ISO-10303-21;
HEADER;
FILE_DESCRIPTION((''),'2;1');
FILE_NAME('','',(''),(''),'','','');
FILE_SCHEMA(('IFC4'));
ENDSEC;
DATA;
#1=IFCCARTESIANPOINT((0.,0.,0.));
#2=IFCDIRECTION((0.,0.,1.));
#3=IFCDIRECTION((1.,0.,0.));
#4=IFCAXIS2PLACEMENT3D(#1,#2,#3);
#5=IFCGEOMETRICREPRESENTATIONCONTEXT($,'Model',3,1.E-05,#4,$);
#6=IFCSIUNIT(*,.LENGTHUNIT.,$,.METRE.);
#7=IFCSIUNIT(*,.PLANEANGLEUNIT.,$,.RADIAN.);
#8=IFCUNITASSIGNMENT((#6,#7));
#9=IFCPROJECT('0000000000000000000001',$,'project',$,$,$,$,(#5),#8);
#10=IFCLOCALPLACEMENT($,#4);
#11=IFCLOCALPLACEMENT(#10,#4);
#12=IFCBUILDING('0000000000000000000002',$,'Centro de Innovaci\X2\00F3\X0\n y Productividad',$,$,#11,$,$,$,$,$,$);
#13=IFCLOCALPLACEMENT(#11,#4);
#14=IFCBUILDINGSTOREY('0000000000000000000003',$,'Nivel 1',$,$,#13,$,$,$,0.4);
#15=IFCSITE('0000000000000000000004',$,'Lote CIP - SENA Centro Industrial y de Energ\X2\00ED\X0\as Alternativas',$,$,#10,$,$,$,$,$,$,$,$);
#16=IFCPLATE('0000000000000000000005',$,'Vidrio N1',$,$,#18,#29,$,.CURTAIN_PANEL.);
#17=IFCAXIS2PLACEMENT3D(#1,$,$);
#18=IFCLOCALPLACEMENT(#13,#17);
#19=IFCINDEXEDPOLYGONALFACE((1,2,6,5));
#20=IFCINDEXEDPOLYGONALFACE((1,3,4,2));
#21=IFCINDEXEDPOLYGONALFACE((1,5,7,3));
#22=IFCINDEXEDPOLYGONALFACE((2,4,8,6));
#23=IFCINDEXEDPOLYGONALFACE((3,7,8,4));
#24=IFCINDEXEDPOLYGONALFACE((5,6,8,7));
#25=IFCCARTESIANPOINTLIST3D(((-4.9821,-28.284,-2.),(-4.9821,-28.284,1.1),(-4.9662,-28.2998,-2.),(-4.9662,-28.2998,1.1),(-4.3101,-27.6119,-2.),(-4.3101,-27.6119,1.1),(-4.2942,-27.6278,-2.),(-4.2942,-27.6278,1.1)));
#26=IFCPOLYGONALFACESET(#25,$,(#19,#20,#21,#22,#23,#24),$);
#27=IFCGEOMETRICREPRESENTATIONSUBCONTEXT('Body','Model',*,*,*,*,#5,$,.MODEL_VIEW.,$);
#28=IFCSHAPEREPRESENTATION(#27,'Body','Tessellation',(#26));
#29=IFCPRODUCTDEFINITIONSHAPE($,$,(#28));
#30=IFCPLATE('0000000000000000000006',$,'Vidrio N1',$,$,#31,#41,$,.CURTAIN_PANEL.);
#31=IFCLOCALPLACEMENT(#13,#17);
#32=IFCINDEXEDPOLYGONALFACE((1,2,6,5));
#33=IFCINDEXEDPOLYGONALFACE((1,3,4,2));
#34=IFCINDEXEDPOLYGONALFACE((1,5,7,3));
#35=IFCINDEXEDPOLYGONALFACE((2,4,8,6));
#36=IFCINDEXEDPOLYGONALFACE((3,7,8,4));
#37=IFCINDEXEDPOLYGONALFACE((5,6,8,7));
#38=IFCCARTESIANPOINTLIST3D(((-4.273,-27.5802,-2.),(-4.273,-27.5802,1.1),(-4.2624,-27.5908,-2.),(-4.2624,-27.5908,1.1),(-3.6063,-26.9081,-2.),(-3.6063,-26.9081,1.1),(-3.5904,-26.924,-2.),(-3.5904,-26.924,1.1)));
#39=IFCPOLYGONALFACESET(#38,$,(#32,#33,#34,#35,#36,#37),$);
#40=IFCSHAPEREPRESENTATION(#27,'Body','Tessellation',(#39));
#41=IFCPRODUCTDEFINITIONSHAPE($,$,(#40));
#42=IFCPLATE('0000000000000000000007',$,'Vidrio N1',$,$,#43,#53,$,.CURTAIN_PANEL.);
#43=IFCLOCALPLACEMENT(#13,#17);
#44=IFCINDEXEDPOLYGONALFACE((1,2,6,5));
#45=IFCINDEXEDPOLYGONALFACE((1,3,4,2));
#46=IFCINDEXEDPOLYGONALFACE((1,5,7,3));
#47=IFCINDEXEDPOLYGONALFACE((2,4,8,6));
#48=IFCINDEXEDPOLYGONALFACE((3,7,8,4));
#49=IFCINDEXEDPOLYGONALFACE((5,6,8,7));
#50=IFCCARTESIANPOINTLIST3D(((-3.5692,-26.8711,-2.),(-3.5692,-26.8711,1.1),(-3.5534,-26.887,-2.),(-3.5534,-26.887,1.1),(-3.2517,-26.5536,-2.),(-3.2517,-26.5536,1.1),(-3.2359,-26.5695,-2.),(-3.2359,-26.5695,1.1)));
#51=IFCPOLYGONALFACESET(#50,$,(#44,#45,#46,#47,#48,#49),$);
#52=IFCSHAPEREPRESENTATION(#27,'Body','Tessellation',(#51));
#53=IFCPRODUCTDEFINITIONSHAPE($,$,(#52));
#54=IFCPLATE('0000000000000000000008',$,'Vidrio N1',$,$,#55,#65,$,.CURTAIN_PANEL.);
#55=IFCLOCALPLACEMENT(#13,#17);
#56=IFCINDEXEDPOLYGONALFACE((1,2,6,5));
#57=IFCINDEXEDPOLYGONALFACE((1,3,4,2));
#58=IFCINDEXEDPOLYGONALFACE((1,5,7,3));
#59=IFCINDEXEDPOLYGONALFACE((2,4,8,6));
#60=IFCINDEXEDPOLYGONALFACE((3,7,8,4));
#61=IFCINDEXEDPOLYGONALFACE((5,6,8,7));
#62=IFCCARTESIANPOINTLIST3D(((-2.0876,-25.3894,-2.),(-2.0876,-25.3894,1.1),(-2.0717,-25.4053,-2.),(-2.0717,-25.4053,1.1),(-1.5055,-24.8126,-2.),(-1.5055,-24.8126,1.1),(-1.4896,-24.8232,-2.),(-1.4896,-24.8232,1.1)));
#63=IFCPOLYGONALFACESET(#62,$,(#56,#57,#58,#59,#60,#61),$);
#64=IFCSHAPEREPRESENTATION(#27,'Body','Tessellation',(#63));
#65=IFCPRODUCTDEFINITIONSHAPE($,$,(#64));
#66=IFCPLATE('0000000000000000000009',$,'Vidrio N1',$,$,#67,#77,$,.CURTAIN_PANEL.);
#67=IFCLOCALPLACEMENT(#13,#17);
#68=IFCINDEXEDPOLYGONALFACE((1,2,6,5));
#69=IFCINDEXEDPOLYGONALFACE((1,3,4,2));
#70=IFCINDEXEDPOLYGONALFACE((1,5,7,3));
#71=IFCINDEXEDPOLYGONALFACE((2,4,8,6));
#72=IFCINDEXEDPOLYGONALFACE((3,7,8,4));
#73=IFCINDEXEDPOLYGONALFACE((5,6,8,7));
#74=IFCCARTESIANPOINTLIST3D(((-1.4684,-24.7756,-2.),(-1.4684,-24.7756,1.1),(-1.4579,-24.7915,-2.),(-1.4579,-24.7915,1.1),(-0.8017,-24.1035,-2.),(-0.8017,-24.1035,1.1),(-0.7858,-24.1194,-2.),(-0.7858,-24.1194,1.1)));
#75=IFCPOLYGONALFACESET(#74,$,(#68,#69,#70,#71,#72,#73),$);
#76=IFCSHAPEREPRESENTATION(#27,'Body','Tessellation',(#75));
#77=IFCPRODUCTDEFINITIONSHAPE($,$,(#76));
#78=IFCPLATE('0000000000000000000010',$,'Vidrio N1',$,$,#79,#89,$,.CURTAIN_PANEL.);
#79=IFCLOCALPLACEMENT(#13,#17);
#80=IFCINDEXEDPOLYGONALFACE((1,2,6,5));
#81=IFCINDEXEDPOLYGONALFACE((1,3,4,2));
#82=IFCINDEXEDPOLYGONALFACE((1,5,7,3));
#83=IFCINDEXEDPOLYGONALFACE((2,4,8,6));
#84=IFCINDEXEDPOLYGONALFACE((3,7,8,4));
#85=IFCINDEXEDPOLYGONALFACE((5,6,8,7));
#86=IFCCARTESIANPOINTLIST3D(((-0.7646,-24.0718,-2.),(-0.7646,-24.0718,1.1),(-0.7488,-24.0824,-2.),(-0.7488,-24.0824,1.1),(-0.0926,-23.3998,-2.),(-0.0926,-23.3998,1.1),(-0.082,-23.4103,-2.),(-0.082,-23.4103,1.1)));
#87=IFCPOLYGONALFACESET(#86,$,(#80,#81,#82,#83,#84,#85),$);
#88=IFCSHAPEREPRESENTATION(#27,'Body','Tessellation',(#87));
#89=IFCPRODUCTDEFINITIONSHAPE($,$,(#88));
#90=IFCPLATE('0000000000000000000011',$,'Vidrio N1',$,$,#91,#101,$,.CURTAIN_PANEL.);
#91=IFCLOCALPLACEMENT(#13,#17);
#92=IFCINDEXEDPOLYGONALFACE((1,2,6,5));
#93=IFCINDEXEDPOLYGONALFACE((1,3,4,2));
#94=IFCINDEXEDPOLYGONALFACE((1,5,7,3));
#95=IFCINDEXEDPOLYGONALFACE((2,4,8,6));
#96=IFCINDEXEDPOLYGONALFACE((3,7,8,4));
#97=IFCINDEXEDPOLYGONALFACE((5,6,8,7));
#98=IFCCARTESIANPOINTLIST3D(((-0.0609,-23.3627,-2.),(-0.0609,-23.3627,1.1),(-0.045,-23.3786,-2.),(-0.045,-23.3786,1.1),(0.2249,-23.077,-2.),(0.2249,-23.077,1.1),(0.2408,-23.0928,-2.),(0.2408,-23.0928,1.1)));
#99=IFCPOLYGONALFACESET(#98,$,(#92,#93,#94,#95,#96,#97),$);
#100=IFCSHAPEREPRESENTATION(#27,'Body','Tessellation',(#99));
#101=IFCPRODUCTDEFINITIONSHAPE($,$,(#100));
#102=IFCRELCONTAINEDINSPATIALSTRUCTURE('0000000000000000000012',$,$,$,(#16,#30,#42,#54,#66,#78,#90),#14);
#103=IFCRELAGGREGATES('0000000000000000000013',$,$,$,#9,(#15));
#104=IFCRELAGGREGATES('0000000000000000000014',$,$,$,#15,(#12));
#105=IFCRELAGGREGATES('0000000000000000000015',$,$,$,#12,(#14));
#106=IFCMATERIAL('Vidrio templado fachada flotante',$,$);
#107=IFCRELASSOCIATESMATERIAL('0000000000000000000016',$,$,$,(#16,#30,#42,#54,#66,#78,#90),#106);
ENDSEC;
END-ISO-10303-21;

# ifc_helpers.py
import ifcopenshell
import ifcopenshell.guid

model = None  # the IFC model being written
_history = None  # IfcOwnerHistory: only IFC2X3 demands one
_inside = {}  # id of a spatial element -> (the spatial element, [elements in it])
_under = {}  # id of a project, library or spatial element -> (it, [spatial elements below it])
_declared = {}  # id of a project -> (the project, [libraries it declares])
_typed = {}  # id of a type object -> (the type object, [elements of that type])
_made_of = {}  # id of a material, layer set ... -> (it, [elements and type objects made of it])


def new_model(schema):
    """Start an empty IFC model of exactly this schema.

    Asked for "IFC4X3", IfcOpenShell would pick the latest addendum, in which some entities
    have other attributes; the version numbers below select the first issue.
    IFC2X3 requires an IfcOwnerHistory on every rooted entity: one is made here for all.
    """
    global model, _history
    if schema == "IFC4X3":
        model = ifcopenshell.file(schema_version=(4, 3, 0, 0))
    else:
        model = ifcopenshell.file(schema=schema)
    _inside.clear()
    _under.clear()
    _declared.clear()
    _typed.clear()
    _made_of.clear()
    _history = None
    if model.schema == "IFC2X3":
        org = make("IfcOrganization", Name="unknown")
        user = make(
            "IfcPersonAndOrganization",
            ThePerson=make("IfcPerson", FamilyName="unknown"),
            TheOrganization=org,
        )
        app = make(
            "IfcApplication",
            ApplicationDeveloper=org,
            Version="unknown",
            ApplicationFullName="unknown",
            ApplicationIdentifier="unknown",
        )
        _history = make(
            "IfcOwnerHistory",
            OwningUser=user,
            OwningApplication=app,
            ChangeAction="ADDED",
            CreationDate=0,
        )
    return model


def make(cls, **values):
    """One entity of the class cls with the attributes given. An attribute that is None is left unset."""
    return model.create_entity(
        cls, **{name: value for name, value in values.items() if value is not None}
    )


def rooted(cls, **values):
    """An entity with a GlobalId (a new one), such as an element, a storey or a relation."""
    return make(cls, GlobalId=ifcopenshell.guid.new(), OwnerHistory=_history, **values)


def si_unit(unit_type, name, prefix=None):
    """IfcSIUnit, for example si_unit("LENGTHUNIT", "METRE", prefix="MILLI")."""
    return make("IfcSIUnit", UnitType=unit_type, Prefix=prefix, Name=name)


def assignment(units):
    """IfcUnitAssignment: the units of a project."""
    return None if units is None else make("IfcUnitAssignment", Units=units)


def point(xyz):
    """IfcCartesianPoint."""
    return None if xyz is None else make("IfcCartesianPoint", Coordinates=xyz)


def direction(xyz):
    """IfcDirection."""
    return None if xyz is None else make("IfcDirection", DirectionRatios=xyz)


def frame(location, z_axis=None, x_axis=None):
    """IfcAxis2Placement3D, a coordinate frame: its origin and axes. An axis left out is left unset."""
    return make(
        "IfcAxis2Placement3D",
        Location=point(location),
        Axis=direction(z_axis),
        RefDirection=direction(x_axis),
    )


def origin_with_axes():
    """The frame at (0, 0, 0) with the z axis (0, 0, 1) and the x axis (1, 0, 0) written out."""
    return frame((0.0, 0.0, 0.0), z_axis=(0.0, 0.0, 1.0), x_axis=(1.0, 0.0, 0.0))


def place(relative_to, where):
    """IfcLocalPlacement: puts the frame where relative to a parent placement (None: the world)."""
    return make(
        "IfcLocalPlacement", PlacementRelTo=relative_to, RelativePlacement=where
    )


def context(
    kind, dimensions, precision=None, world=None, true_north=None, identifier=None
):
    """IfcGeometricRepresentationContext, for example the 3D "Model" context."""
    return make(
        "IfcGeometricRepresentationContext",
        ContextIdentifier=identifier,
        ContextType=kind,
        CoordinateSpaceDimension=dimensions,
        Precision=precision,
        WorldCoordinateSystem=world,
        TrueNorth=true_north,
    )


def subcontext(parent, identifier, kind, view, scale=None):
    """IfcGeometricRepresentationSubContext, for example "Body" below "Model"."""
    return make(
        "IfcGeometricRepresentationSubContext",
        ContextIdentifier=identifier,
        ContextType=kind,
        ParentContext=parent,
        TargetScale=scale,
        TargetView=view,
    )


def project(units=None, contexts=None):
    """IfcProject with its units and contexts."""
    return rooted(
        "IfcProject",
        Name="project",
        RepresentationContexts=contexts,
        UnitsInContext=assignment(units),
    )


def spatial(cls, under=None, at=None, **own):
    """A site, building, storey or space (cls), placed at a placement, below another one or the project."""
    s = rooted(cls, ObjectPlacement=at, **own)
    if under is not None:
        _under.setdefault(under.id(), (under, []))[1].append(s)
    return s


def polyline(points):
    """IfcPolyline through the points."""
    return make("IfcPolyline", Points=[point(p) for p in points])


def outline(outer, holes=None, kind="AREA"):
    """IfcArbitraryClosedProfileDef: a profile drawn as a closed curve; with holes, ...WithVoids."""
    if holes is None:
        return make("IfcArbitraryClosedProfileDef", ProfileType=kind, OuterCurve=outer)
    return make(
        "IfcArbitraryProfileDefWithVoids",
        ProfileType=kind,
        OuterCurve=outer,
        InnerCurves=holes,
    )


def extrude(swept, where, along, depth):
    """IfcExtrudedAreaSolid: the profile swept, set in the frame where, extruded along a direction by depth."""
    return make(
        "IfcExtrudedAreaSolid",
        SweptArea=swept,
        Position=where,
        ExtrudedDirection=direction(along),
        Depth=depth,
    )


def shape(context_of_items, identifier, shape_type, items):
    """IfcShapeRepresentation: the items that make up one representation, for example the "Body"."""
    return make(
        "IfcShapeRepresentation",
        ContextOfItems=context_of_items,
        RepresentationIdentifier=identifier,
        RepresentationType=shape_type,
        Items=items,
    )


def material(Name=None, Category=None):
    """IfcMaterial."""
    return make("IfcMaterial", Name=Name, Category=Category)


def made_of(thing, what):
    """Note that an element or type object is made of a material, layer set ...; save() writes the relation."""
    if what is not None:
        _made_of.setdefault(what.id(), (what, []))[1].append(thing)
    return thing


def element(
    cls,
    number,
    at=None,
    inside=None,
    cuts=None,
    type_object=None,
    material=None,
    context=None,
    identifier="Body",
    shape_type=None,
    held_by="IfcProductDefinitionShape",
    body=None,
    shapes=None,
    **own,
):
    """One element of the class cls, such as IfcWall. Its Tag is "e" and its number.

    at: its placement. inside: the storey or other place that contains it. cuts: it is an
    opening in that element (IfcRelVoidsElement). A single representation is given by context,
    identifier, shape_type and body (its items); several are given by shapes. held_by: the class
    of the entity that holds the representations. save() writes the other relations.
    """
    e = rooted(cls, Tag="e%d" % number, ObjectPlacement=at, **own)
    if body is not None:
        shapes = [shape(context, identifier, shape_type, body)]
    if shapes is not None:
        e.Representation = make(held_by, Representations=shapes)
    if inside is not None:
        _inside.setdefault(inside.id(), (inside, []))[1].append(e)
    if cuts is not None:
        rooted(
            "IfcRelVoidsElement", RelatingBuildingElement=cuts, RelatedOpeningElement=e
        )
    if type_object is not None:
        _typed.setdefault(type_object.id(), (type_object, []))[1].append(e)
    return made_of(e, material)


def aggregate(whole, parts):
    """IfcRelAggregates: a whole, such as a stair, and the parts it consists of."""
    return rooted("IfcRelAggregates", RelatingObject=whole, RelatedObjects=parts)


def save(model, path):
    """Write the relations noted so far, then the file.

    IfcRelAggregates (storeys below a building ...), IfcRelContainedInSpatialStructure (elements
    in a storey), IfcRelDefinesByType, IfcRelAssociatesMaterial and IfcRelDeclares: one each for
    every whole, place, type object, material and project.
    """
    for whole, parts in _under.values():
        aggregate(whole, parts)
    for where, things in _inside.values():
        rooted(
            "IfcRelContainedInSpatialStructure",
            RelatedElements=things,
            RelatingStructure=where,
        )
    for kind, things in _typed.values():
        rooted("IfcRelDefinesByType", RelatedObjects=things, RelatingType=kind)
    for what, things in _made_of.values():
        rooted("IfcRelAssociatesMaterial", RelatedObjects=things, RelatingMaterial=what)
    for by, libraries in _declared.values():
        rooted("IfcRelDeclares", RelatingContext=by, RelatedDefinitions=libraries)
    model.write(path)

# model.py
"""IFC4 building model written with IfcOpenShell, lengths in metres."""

from ifc_helpers import new_model, si_unit, frame, origin_with_axes, place, context, subcontext, project, spatial, polyline, outline, extrude, material, element, save


model = new_model("IFC4")

# Units and contexts
model_context = context("Model", 3, precision=1e-05, world=origin_with_axes())
body_context = subcontext(model_context, "Body", "Model", "MODEL_VIEW")
ifc_project = project(units=[si_unit("LENGTHUNIT", "METRE"), si_unit("PLANEANGLEUNIT", "RADIAN")], contexts=[model_context])

# Site, building, storey
site_placement = place(None, origin_with_axes())
site = spatial("IfcSite", under=ifc_project, at=site_placement, Name="Lote CIP - SENA Centro Industrial y de Energías Alternativas")
building_placement = place(site_placement, origin_with_axes())
building = spatial("IfcBuilding", under=site, at=building_placement, Name="Centro de Innovación y Productividad")
storey_placement = place(building_placement, origin_with_axes())
storey = spatial("IfcBuildingStorey", under=building, at=storey_placement, Name="Nivel 1", Elevation=0.4)

# Plates
ifc_material_1 = material(Name="Vidrio templado fachada flotante")
plate_1_placement = place(storey_placement, frame((0.0, 0.0, -2.4), z_axis=(0.0, 0.0, 1.0), x_axis=(1.0, 0.0, 0.0)))
element("IfcPlate", 1, at=plate_1_placement, inside=storey, material=ifc_material_1, Name="Vidrio N1", PredefinedType="CURTAIN_PANEL", context=body_context, shape_type="SweptSolid", body=[
    extrude(outline(polyline([(-4.9662, -28.2998), (-4.9821, -28.284), (-4.3101, -27.6119), (-4.2942, -27.6278), (-4.9662, -28.2998)])), frame((0.0, 0.0, 0.4)), (0.0, 0.0, 1.0), 3.1),
])
plate_2_placement = place(storey_placement, frame((0.0, 0.0, -2.4), z_axis=(0.0, 0.0, 1.0), x_axis=(1.0, 0.0, 0.0)))
element("IfcPlate", 2, at=plate_2_placement, inside=storey, material=ifc_material_1, Name="Vidrio N1", PredefinedType="CURTAIN_PANEL", context=body_context, shape_type="SweptSolid", body=[
    extrude(outline(polyline([(-4.2624, -27.5907), (-4.273, -27.5802), (-3.6063, -26.9081), (-3.5904, -26.924), (-4.2624, -27.5907)])), frame((0.0, 0.0, 0.4)), (0.0, 0.0, 1.0), 3.1),
])
plate_3_placement = place(storey_placement, frame((0.0, 0.0, -2.4), z_axis=(0.0, 0.0, 1.0), x_axis=(1.0, 0.0, 0.0)))
element("IfcPlate", 3, at=plate_3_placement, inside=storey, material=ifc_material_1, Name="Vidrio N1", PredefinedType="CURTAIN_PANEL", context=body_context, shape_type="SweptSolid", body=[
    extrude(outline(polyline([(-3.2359, -26.5695), (-3.5534, -26.887), (-3.5692, -26.8711), (-3.2517, -26.5536), (-3.2359, -26.5695)])), frame((0.0, 0.0, 0.4)), (0.0, 0.0, 1.0), 3.1),
])
plate_4_placement = place(storey_placement, frame((0.0, 0.0, -2.4), z_axis=(0.0, 0.0, 1.0), x_axis=(1.0, 0.0, 0.0)))
element("IfcPlate", 4, at=plate_4_placement, inside=storey, material=ifc_material_1, Name="Vidrio N1", PredefinedType="CURTAIN_PANEL", context=body_context, shape_type="SweptSolid", body=[
    extrude(outline(polyline([(-2.0876, -25.3894), (-1.5055, -24.8126), (-1.4896, -24.8232), (-2.0717, -25.4053), (-2.0876, -25.3894)])), frame((0.0, 0.0, 0.4)), (0.0, 0.0, 1.0), 3.1),
])
plate_5_placement = place(storey_placement, frame((0.0, 0.0, -2.4), z_axis=(0.0, 0.0, 1.0), x_axis=(1.0, 0.0, 0.0)))
element("IfcPlate", 5, at=plate_5_placement, inside=storey, material=ifc_material_1, Name="Vidrio N1", PredefinedType="CURTAIN_PANEL", context=body_context, shape_type="SweptSolid", body=[
    extrude(outline(polyline([(-1.4579, -24.7915), (-1.4684, -24.7756), (-0.8017, -24.1035), (-0.7858, -24.1194), (-1.4579, -24.7915)])), frame((0.0, 0.0, 0.4)), (0.0, 0.0, 1.0), 3.1),
])
plate_6_placement = place(storey_placement, frame((0.0, 0.0, -2.4), z_axis=(0.0, 0.0, 1.0), x_axis=(1.0, 0.0, 0.0)))
element("IfcPlate", 6, at=plate_6_placement, inside=storey, material=ifc_material_1, Name="Vidrio N1", PredefinedType="CURTAIN_PANEL", context=body_context, shape_type="SweptSolid", body=[
    extrude(outline(polyline([(-0.7488, -24.0824), (-0.7646, -24.0718), (-0.0926, -23.3998), (-0.082, -23.4103), (-0.7488, -24.0824)])), frame((0.0, 0.0, 0.4)), (0.0, 0.0, 1.0), 3.1),
])
plate_7_placement = place(storey_placement, frame((0.0, 0.0, -2.4), z_axis=(0.0, 0.0, 1.0), x_axis=(1.0, 0.0, 0.0)))
element("IfcPlate", 7, at=plate_7_placement, inside=storey, material=ifc_material_1, Name="Vidrio N1", PredefinedType="CURTAIN_PANEL", context=body_context, shape_type="SweptSolid", body=[
    extrude(outline(polyline([(-0.045, -23.3786), (-0.0609, -23.3627), (0.2249, -23.077), (0.2408, -23.0928), (-0.045, -23.3786)])), frame((0.0, 0.0, 0.4)), (0.0, 0.0, 1.0), 3.1),
])

save(model, "model.ifc")
